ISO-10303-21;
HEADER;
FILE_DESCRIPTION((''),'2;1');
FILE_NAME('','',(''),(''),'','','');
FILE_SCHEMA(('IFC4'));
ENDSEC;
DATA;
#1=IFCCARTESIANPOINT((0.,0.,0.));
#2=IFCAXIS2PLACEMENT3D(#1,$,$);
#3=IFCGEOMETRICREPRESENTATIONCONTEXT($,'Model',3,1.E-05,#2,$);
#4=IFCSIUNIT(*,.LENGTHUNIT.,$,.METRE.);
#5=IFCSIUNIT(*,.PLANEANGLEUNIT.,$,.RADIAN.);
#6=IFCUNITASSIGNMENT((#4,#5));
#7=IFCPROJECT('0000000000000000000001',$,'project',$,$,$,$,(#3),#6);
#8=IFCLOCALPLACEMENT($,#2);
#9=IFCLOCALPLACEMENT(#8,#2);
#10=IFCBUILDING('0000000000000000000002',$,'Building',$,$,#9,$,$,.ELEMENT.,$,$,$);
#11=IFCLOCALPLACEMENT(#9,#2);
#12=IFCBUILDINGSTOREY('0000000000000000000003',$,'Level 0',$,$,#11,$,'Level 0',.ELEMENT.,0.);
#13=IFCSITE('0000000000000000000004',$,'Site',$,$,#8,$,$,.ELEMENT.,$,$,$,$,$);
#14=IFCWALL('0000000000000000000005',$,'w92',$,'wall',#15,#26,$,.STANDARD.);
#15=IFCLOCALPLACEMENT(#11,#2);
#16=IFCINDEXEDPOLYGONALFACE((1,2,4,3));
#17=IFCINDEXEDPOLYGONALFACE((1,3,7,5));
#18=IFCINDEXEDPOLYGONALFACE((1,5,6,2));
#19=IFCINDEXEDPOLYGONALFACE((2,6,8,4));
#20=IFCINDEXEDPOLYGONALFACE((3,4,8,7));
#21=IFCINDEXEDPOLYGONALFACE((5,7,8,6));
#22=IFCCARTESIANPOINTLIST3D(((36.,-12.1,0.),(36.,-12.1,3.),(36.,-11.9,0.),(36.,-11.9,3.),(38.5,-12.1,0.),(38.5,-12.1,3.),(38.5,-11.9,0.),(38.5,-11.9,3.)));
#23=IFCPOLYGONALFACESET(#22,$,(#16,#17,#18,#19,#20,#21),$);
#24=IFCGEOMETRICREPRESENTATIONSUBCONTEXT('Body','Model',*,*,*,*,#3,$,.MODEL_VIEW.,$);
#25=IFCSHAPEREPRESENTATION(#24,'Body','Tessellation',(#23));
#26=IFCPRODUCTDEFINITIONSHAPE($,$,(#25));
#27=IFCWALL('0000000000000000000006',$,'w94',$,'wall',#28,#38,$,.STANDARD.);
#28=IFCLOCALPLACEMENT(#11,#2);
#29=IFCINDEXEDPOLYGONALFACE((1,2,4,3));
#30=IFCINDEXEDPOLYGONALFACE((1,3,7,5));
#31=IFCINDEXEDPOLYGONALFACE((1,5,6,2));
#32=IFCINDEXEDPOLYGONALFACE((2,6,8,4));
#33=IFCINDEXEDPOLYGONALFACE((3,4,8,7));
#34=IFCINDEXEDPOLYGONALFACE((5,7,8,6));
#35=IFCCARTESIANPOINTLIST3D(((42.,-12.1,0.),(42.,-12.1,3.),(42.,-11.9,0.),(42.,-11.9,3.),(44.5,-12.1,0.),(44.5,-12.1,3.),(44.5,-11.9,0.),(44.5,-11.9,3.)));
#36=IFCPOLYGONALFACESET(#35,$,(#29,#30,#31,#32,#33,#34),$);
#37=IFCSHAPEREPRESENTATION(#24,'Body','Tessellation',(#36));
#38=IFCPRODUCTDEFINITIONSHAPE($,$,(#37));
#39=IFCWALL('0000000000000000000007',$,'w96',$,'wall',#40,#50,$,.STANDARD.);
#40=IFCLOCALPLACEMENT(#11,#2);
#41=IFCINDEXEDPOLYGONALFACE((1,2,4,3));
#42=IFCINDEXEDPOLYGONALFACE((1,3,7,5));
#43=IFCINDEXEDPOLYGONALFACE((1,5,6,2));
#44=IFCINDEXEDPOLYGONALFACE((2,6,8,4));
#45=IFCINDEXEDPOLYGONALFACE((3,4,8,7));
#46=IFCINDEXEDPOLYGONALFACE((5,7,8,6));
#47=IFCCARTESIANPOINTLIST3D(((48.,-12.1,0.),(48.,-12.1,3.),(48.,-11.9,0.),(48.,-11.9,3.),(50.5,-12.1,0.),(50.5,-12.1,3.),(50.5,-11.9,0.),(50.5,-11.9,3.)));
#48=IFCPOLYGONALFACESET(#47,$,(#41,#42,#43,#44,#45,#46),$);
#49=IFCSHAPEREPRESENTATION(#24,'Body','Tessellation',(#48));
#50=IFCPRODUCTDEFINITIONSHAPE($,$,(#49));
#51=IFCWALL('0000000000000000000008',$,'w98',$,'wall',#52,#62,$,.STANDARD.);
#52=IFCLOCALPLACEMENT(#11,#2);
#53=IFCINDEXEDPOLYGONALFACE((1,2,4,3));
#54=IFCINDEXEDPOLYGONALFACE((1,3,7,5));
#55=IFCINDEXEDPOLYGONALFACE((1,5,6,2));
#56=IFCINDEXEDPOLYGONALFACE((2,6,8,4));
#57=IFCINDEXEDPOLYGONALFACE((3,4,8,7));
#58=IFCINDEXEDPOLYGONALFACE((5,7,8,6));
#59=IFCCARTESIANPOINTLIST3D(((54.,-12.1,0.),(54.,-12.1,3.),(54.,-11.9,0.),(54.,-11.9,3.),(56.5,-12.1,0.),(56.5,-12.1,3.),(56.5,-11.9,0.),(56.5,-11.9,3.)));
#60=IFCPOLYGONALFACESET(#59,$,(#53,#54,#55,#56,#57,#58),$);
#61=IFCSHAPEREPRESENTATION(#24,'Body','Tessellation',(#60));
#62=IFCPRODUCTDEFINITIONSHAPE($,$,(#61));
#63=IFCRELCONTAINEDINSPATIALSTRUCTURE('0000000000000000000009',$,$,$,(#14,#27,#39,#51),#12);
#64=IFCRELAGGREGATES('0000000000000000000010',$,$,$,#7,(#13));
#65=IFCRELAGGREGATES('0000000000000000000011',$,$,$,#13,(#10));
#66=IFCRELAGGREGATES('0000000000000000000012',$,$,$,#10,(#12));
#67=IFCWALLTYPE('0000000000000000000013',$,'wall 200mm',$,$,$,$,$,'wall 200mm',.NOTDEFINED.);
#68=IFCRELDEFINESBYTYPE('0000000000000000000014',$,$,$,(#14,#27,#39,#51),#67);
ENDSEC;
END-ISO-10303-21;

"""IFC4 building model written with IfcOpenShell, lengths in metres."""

from ifc_helpers import new_model, si_unit, frame, frame_2d, origin, place, context, subcontext, project, spatial, rectangle, extrude, type_object, element, save


model = new_model("IFC4")

# Units and contexts
model_context = context("Model", 3, precision=1e-05, world=origin())
body_context = subcontext(model_context, "Body", "Model", "MODEL_VIEW")
ifc_project = project(units=[si_unit("LENGTHUNIT", "METRE"), si_unit("PLANEANGLEUNIT", "RADIAN")], contexts=[model_context])

# Site, building, storey
site_placement = place(None, origin())
site = spatial("IfcSite", under=ifc_project, at=site_placement, Name="Site", CompositionType="ELEMENT")
building_placement = place(site_placement, origin())
building = spatial("IfcBuilding", under=site, at=building_placement, Name="Building", CompositionType="ELEMENT")
storey_placement = place(building_placement, origin())
storey = spatial("IfcBuildingStorey", under=building, at=storey_placement, Name="Level 0", LongName="Level 0", CompositionType="ELEMENT", Elevation=0.0)

# Walls
wall_type = type_object("IfcWallType", Name="wall 200mm", ElementType="wall 200mm", PredefinedType="NOTDEFINED")
for number, where, z_axis, x_axis, name in (
    (1, (36.0, -12.0, 0.0), (0.0, 0.0, 1.0), (1.0, 0.0, 0.0), "w92"),
    (2, (42.0, -12.0, 0.0), (0.0, 0.0, 1.0), (1.0, 0.0, 0.0), "w94"),
    (3, (48.0, -12.0, 0.0), (0.0, 0.0, 1.0), (1.0, 0.0, 0.0), "w96"),
    (4, (54.0, -12.0, 0.0), (0.0, 0.0, 1.0), (1.0, 0.0, 0.0), "w98"),
):
    element("IfcWall", number, at=place(storey_placement, frame(where, z_axis=z_axis, x_axis=x_axis)), inside=storey, type_object=wall_type, Name=name, ObjectType="wall", PredefinedType="STANDARD", context=body_context, shape_type="SweptSolid", body=[
        extrude(rectangle(XDim=2.5, YDim=0.2, at=frame_2d((1.25, 0.0))), origin(), (0.0, 0.0, 1.0), 3.0),
    ])

save(model, "model.ifc")
